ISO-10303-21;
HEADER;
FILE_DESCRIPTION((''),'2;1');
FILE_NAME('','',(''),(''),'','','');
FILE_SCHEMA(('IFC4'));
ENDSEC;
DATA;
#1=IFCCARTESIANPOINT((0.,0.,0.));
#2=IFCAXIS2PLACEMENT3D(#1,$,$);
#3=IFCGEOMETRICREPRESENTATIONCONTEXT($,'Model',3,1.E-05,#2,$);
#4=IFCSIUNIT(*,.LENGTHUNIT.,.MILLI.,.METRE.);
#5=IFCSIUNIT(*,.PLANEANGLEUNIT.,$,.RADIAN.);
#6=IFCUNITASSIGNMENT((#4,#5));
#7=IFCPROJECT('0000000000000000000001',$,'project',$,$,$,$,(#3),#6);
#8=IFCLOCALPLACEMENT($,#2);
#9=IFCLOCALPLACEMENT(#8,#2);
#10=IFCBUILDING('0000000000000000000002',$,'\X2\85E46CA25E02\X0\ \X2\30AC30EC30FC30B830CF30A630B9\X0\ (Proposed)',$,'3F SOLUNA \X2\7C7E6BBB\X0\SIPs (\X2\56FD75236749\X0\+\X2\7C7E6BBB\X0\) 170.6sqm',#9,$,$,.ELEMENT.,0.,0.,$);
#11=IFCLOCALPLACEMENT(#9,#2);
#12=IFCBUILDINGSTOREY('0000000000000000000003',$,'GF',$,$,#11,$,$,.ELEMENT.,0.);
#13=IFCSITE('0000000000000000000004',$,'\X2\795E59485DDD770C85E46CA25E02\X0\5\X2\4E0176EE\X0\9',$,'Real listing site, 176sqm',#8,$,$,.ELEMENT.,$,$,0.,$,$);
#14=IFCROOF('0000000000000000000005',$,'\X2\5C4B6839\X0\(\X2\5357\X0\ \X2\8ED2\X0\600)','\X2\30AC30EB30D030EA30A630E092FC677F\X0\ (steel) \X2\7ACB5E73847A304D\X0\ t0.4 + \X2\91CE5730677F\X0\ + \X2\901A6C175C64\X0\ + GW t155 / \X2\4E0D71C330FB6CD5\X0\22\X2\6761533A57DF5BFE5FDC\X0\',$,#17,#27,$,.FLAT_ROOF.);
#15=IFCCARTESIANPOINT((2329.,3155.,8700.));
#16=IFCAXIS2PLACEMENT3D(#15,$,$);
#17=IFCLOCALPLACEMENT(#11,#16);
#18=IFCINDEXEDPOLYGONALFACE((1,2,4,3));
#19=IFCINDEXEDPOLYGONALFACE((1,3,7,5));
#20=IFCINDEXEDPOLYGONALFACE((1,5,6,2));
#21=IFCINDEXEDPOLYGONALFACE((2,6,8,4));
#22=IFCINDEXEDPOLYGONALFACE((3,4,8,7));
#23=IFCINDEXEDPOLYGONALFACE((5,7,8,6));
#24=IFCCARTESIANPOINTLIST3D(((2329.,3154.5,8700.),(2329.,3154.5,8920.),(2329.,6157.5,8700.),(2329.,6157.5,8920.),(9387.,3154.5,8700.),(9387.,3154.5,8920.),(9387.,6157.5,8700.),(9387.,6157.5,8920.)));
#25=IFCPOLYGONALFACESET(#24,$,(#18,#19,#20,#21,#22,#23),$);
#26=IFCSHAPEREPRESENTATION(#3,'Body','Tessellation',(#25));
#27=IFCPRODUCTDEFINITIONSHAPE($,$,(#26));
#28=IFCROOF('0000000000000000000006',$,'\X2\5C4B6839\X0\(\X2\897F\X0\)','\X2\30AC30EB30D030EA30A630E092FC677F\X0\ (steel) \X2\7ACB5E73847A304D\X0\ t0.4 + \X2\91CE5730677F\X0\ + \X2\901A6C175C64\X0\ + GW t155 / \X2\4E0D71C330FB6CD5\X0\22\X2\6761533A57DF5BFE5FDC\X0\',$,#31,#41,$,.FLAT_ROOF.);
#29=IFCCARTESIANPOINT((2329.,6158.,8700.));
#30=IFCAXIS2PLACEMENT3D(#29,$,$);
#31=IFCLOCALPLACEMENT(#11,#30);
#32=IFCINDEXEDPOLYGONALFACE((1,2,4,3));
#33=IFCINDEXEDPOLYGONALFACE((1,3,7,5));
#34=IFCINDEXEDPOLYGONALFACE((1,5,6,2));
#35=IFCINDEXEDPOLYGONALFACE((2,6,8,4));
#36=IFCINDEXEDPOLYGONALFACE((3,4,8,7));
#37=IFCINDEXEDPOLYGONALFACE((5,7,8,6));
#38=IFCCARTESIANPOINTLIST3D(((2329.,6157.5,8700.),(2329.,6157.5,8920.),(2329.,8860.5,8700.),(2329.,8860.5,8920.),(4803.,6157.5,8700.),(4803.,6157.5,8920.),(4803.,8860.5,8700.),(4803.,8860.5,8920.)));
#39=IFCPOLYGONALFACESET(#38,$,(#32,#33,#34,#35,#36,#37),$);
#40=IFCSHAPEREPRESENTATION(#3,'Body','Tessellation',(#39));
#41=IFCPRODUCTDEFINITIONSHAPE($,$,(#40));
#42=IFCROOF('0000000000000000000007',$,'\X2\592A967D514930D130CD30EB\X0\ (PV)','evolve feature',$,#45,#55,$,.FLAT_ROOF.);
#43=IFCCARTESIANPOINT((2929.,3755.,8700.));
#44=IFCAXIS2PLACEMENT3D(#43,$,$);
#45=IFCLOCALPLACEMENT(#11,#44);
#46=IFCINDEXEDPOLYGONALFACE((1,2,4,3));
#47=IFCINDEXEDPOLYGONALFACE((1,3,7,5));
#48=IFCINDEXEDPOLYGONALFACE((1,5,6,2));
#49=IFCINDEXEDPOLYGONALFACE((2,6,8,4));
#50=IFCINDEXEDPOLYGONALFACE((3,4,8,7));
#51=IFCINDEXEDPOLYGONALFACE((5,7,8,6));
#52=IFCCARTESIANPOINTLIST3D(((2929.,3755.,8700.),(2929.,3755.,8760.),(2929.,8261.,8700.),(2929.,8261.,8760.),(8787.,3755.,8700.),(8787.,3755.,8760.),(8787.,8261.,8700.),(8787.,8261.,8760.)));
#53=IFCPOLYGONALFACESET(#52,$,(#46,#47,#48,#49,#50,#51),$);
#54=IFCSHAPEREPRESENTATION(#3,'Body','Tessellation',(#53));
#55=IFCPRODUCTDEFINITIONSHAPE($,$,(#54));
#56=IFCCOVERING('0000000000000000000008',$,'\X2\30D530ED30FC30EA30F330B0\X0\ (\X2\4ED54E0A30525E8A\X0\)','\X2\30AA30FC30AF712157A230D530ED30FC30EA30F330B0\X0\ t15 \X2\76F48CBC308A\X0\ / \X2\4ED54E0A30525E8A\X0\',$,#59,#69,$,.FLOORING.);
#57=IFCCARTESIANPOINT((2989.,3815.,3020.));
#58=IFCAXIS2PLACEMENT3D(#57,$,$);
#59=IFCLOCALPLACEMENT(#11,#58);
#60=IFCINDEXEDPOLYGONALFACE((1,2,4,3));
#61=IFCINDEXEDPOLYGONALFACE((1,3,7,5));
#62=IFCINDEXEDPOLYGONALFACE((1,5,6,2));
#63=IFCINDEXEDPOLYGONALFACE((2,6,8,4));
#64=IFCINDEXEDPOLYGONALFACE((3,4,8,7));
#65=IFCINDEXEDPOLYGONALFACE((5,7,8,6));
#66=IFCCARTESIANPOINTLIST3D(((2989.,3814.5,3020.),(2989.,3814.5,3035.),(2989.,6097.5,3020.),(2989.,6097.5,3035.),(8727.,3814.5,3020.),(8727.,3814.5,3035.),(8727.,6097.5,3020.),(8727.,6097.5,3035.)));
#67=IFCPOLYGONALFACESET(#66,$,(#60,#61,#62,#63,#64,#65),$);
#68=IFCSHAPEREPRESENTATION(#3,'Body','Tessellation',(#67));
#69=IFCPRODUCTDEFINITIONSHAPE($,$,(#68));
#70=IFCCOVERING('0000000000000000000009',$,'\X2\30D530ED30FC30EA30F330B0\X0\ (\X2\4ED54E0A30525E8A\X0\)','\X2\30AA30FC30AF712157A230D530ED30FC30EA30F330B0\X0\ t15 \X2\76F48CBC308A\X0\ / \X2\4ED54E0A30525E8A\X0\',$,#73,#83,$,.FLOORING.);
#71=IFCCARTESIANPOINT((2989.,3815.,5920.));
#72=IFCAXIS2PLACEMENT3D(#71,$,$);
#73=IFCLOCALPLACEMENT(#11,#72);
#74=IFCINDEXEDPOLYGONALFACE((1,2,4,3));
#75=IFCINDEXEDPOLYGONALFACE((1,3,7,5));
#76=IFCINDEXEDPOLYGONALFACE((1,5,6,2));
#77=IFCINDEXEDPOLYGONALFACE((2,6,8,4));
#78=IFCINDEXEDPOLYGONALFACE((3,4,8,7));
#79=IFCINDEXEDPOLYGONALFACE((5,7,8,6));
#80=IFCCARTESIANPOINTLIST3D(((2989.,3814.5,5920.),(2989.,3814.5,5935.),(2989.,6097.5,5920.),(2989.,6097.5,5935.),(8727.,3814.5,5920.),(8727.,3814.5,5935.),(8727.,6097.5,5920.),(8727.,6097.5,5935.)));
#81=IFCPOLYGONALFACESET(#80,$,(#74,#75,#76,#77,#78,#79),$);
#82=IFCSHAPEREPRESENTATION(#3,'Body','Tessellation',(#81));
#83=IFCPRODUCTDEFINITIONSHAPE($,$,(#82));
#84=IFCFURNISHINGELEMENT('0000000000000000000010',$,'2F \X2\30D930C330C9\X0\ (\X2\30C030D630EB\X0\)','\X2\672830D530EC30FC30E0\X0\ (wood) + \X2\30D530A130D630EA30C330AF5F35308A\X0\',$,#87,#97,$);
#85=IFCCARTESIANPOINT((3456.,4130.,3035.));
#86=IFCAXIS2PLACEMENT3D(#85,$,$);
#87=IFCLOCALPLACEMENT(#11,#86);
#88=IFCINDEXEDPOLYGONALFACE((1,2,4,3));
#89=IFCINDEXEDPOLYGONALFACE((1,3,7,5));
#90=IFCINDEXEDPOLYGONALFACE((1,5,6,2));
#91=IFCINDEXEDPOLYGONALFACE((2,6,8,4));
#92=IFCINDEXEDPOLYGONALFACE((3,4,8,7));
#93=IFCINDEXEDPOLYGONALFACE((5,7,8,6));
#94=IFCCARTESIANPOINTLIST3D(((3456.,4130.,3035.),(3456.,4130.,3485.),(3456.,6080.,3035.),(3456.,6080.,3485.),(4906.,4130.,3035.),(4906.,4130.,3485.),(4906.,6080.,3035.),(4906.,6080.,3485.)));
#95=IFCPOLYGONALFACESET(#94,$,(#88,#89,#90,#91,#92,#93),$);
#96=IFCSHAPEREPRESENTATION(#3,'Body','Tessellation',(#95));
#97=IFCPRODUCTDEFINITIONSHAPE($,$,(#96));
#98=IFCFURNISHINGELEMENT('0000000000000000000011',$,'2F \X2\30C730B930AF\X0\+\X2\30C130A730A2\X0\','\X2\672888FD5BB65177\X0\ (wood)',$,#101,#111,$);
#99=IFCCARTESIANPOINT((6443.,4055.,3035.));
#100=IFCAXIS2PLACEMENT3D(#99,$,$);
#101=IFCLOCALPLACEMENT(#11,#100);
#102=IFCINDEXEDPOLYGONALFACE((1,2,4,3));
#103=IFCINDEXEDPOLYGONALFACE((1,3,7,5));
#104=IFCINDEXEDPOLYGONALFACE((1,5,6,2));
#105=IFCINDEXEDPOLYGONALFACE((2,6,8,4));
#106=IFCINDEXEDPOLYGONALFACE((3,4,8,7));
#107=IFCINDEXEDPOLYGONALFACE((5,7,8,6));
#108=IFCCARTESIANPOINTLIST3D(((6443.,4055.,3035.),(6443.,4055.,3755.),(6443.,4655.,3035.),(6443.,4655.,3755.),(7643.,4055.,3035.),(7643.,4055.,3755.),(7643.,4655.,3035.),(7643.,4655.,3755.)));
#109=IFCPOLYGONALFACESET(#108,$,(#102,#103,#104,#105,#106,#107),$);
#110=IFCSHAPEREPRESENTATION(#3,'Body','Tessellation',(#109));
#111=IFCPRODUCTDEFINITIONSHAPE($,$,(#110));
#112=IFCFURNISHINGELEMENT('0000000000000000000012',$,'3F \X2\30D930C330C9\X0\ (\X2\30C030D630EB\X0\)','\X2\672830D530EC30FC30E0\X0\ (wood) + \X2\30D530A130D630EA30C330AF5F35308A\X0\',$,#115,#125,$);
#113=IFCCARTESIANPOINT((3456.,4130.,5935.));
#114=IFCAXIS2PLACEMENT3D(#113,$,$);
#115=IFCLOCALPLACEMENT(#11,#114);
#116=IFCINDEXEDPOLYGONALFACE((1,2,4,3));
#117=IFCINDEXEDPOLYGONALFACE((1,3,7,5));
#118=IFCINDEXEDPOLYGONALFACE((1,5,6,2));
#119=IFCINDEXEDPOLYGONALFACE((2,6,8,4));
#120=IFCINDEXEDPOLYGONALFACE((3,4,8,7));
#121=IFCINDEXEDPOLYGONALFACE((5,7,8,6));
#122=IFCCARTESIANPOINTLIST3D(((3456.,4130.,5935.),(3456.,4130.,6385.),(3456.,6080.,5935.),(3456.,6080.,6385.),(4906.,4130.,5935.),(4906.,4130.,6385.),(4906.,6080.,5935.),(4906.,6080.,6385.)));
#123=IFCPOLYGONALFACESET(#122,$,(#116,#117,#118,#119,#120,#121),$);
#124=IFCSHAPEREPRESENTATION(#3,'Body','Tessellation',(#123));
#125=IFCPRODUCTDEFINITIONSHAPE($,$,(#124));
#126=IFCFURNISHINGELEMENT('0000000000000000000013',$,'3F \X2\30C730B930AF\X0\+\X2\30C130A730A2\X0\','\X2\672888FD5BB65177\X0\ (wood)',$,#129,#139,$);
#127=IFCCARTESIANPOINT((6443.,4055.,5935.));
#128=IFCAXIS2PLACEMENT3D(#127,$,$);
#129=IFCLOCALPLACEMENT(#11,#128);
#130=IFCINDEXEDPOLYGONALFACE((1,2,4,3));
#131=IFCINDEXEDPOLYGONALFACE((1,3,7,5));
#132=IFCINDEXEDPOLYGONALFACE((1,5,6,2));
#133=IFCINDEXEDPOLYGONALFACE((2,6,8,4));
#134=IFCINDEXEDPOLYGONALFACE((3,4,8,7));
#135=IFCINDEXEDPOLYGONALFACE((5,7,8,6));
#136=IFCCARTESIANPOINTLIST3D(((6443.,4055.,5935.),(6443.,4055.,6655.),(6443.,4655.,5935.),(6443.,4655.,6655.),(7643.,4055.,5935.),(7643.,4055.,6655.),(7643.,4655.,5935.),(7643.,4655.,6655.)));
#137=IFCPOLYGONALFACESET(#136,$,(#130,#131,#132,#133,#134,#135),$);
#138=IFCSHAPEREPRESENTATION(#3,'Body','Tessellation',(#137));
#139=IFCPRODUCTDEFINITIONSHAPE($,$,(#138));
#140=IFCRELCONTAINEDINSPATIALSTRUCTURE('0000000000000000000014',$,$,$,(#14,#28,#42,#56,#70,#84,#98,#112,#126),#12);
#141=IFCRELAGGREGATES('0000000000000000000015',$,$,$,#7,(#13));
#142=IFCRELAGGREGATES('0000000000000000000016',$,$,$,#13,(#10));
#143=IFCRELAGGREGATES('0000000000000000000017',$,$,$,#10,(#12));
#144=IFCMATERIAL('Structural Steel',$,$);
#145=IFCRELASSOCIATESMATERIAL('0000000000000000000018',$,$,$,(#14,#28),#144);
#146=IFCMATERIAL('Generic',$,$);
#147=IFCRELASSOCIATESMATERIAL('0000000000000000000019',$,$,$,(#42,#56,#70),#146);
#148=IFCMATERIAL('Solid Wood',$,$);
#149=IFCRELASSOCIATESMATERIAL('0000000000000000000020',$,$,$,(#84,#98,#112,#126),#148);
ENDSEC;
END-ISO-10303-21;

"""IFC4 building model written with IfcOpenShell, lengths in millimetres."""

from ifc_helpers import new_model, si_unit, frame, frame_2d, origin, place, context, project, spatial, rectangle, extrude, material, element, save


model = new_model("IFC4")

# Units and contexts
model_context = context("Model", 3, precision=1e-05, world=origin())
ifc_project = project(units=[si_unit("LENGTHUNIT", "METRE", prefix="MILLI"), si_unit("PLANEANGLEUNIT", "RADIAN")], contexts=[model_context])

# Site, building, storey
site_placement = place(None, origin())
site = spatial("IfcSite", under=ifc_project, at=site_placement, Name="神奈川県藤沢市5丁目9", ObjectType="Real listing site, 176sqm", CompositionType="ELEMENT", RefElevation=0.0)
building_placement = place(site_placement, origin())
building = spatial("IfcBuilding", under=site, at=building_placement, Name="藤沢市 ガレージハウス (Proposed)", ObjectType="3F SOLUNA 籾殻SIPs (国産杉+籾殻) 170.6sqm", CompositionType="ELEMENT", ElevationOfRefHeight=0.0, ElevationOfTerrain=0.0)
storey_placement = place(building_placement, origin())
storey = spatial("IfcBuildingStorey", under=building, at=storey_placement, Name="GF", CompositionType="ELEMENT", Elevation=0.0)

# Shared definitions
ifc_material_1 = material(Name="Solid Wood")

# Roofs
ifc_material_2 = material(Name="Structural Steel")
roof_1_placement = place(storey_placement, frame((2329.0, 3155.0, 8700.0)))
element("IfcRoof", 1, at=roof_1_placement, inside=storey, material=ifc_material_2, Name="屋根(南 軒600)", Description="ガルバリウム鋼板 (steel) 立平葺き t0.4 + 野地板 + 通気層 + GW t155 / 不燃・法22条区域対応", PredefinedType="FLAT_ROOF", context=model_context, shape_type="SweptSolid", body=[
    extrude(rectangle(XDim=7058.0, YDim=3003.0, at=frame_2d((3529.0, 1501.0))), frame((2329.0, 3155.0, 8700.0)), (0.0, 0.0, 1.0), 220.0),
])
roof_2_placement = place(storey_placement, frame((2329.0, 6158.0, 8700.0)))
element("IfcRoof", 2, at=roof_2_placement, inside=storey, material=ifc_material_2, Name="屋根(西)", Description="ガルバリウム鋼板 (steel) 立平葺き t0.4 + 野地板 + 通気層 + GW t155 / 不燃・法22条区域対応", PredefinedType="FLAT_ROOF", context=model_context, shape_type="SweptSolid", body=[
    extrude(rectangle(XDim=2474.0, YDim=2703.0, at=frame_2d((1237.0, 1351.0))), frame((2329.0, 6158.0, 8700.0)), (0.0, 0.0, 1.0), 220.0),
])
ifc_material_3 = material(Name="Generic")
roof_3_placement = place(storey_placement, frame((2929.0, 3755.0, 8700.0)))
element("IfcRoof", 3, at=roof_3_placement, inside=storey, material=ifc_material_3, Name="太陽光パネル (PV)", Description="evolve feature", PredefinedType="FLAT_ROOF", context=model_context, shape_type="SweptSolid", body=[
    extrude(rectangle(XDim=5858.0, YDim=4506.0, at=frame_2d((2929.0, 2253.0))), frame((2929.0, 3755.0, 8700.0)), (0.0, 0.0, 1.0), 60.0),
])

# Coverings
covering_1_placement = place(storey_placement, frame((2989.0, 3815.0, 3020.0)))
element("IfcCovering", 4, at=covering_1_placement, inside=storey, material=ifc_material_3, Name="フローリング (仕上げ床)", Description="オーク無垢フローリング t15 直貼り / 仕上げ床", PredefinedType="FLOORING", context=model_context, shape_type="SweptSolid", body=[
    extrude(rectangle(XDim=5738.0, YDim=2283.0, at=frame_2d((2869.0, 1141.0))), frame((2989.0, 3815.0, 3020.0)), (0.0, 0.0, 1.0), 15.0),
])
covering_2_placement = place(storey_placement, frame((2989.0, 3815.0, 5920.0)))
element("IfcCovering", 5, at=covering_2_placement, inside=storey, material=ifc_material_3, Name="フローリング (仕上げ床)", Description="オーク無垢フローリング t15 直貼り / 仕上げ床", PredefinedType="FLOORING", context=model_context, shape_type="SweptSolid", body=[
    extrude(rectangle(XDim=5738.0, YDim=2283.0, at=frame_2d((2869.0, 1141.0))), frame((2989.0, 3815.0, 5920.0)), (0.0, 0.0, 1.0), 15.0),
])

# Furnishing elements
furnishing_1_placement = place(storey_placement, frame((3456.0, 4130.0, 3035.0)))
element("IfcFurnishingElement", 6, at=furnishing_1_placement, inside=storey, material=ifc_material_1, Name="2F ベッド (ダブル)", Description="木フレーム (wood) + ファブリック張り", context=model_context, shape_type="SweptSolid", body=[
    extrude(rectangle(XDim=1450.0, YDim=1950.0, at=frame_2d((725.0, 975.0))), frame((3456.0, 4130.0, 3035.0)), (0.0, 0.0, 1.0), 450.0),
])
furnishing_2_placement = place(storey_placement, frame((6443.0, 4055.0, 3035.0)))
element("IfcFurnishingElement", 7, at=furnishing_2_placement, inside=storey, material=ifc_material_1, Name="2F デスク+チェア", Description="木製家具 (wood)", context=model_context, shape_type="SweptSolid", body=[
    extrude(rectangle(XDim=1200.0, YDim=600.0, at=frame_2d((600.0, 300.0))), frame((6443.0, 4055.0, 3035.0)), (0.0, 0.0, 1.0), 720.0),
])
furnishing_3_placement = place(storey_placement, frame((3456.0, 4130.0, 5935.0)))
element("IfcFurnishingElement", 8, at=furnishing_3_placement, inside=storey, material=ifc_material_1, Name="3F ベッド (ダブル)", Description="木フレーム (wood) + ファブリック張り", context=model_context, shape_type="SweptSolid", body=[
    extrude(rectangle(XDim=1450.0, YDim=1950.0, at=frame_2d((725.0, 975.0))), frame((3456.0, 4130.0, 5935.0)), (0.0, 0.0, 1.0), 450.0),
])
furnishing_4_placement = place(storey_placement, frame((6443.0, 4055.0, 5935.0)))
element("IfcFurnishingElement", 9, at=furnishing_4_placement, inside=storey, material=ifc_material_1, Name="3F デスク+チェア", Description="木製家具 (wood)", context=model_context, shape_type="SweptSolid", body=[
    extrude(rectangle(XDim=1200.0, YDim=600.0, at=frame_2d((600.0, 300.0))), frame((6443.0, 4055.0, 5935.0)), (0.0, 0.0, 1.0), 720.0),
])

save(model, "model.ifc")
